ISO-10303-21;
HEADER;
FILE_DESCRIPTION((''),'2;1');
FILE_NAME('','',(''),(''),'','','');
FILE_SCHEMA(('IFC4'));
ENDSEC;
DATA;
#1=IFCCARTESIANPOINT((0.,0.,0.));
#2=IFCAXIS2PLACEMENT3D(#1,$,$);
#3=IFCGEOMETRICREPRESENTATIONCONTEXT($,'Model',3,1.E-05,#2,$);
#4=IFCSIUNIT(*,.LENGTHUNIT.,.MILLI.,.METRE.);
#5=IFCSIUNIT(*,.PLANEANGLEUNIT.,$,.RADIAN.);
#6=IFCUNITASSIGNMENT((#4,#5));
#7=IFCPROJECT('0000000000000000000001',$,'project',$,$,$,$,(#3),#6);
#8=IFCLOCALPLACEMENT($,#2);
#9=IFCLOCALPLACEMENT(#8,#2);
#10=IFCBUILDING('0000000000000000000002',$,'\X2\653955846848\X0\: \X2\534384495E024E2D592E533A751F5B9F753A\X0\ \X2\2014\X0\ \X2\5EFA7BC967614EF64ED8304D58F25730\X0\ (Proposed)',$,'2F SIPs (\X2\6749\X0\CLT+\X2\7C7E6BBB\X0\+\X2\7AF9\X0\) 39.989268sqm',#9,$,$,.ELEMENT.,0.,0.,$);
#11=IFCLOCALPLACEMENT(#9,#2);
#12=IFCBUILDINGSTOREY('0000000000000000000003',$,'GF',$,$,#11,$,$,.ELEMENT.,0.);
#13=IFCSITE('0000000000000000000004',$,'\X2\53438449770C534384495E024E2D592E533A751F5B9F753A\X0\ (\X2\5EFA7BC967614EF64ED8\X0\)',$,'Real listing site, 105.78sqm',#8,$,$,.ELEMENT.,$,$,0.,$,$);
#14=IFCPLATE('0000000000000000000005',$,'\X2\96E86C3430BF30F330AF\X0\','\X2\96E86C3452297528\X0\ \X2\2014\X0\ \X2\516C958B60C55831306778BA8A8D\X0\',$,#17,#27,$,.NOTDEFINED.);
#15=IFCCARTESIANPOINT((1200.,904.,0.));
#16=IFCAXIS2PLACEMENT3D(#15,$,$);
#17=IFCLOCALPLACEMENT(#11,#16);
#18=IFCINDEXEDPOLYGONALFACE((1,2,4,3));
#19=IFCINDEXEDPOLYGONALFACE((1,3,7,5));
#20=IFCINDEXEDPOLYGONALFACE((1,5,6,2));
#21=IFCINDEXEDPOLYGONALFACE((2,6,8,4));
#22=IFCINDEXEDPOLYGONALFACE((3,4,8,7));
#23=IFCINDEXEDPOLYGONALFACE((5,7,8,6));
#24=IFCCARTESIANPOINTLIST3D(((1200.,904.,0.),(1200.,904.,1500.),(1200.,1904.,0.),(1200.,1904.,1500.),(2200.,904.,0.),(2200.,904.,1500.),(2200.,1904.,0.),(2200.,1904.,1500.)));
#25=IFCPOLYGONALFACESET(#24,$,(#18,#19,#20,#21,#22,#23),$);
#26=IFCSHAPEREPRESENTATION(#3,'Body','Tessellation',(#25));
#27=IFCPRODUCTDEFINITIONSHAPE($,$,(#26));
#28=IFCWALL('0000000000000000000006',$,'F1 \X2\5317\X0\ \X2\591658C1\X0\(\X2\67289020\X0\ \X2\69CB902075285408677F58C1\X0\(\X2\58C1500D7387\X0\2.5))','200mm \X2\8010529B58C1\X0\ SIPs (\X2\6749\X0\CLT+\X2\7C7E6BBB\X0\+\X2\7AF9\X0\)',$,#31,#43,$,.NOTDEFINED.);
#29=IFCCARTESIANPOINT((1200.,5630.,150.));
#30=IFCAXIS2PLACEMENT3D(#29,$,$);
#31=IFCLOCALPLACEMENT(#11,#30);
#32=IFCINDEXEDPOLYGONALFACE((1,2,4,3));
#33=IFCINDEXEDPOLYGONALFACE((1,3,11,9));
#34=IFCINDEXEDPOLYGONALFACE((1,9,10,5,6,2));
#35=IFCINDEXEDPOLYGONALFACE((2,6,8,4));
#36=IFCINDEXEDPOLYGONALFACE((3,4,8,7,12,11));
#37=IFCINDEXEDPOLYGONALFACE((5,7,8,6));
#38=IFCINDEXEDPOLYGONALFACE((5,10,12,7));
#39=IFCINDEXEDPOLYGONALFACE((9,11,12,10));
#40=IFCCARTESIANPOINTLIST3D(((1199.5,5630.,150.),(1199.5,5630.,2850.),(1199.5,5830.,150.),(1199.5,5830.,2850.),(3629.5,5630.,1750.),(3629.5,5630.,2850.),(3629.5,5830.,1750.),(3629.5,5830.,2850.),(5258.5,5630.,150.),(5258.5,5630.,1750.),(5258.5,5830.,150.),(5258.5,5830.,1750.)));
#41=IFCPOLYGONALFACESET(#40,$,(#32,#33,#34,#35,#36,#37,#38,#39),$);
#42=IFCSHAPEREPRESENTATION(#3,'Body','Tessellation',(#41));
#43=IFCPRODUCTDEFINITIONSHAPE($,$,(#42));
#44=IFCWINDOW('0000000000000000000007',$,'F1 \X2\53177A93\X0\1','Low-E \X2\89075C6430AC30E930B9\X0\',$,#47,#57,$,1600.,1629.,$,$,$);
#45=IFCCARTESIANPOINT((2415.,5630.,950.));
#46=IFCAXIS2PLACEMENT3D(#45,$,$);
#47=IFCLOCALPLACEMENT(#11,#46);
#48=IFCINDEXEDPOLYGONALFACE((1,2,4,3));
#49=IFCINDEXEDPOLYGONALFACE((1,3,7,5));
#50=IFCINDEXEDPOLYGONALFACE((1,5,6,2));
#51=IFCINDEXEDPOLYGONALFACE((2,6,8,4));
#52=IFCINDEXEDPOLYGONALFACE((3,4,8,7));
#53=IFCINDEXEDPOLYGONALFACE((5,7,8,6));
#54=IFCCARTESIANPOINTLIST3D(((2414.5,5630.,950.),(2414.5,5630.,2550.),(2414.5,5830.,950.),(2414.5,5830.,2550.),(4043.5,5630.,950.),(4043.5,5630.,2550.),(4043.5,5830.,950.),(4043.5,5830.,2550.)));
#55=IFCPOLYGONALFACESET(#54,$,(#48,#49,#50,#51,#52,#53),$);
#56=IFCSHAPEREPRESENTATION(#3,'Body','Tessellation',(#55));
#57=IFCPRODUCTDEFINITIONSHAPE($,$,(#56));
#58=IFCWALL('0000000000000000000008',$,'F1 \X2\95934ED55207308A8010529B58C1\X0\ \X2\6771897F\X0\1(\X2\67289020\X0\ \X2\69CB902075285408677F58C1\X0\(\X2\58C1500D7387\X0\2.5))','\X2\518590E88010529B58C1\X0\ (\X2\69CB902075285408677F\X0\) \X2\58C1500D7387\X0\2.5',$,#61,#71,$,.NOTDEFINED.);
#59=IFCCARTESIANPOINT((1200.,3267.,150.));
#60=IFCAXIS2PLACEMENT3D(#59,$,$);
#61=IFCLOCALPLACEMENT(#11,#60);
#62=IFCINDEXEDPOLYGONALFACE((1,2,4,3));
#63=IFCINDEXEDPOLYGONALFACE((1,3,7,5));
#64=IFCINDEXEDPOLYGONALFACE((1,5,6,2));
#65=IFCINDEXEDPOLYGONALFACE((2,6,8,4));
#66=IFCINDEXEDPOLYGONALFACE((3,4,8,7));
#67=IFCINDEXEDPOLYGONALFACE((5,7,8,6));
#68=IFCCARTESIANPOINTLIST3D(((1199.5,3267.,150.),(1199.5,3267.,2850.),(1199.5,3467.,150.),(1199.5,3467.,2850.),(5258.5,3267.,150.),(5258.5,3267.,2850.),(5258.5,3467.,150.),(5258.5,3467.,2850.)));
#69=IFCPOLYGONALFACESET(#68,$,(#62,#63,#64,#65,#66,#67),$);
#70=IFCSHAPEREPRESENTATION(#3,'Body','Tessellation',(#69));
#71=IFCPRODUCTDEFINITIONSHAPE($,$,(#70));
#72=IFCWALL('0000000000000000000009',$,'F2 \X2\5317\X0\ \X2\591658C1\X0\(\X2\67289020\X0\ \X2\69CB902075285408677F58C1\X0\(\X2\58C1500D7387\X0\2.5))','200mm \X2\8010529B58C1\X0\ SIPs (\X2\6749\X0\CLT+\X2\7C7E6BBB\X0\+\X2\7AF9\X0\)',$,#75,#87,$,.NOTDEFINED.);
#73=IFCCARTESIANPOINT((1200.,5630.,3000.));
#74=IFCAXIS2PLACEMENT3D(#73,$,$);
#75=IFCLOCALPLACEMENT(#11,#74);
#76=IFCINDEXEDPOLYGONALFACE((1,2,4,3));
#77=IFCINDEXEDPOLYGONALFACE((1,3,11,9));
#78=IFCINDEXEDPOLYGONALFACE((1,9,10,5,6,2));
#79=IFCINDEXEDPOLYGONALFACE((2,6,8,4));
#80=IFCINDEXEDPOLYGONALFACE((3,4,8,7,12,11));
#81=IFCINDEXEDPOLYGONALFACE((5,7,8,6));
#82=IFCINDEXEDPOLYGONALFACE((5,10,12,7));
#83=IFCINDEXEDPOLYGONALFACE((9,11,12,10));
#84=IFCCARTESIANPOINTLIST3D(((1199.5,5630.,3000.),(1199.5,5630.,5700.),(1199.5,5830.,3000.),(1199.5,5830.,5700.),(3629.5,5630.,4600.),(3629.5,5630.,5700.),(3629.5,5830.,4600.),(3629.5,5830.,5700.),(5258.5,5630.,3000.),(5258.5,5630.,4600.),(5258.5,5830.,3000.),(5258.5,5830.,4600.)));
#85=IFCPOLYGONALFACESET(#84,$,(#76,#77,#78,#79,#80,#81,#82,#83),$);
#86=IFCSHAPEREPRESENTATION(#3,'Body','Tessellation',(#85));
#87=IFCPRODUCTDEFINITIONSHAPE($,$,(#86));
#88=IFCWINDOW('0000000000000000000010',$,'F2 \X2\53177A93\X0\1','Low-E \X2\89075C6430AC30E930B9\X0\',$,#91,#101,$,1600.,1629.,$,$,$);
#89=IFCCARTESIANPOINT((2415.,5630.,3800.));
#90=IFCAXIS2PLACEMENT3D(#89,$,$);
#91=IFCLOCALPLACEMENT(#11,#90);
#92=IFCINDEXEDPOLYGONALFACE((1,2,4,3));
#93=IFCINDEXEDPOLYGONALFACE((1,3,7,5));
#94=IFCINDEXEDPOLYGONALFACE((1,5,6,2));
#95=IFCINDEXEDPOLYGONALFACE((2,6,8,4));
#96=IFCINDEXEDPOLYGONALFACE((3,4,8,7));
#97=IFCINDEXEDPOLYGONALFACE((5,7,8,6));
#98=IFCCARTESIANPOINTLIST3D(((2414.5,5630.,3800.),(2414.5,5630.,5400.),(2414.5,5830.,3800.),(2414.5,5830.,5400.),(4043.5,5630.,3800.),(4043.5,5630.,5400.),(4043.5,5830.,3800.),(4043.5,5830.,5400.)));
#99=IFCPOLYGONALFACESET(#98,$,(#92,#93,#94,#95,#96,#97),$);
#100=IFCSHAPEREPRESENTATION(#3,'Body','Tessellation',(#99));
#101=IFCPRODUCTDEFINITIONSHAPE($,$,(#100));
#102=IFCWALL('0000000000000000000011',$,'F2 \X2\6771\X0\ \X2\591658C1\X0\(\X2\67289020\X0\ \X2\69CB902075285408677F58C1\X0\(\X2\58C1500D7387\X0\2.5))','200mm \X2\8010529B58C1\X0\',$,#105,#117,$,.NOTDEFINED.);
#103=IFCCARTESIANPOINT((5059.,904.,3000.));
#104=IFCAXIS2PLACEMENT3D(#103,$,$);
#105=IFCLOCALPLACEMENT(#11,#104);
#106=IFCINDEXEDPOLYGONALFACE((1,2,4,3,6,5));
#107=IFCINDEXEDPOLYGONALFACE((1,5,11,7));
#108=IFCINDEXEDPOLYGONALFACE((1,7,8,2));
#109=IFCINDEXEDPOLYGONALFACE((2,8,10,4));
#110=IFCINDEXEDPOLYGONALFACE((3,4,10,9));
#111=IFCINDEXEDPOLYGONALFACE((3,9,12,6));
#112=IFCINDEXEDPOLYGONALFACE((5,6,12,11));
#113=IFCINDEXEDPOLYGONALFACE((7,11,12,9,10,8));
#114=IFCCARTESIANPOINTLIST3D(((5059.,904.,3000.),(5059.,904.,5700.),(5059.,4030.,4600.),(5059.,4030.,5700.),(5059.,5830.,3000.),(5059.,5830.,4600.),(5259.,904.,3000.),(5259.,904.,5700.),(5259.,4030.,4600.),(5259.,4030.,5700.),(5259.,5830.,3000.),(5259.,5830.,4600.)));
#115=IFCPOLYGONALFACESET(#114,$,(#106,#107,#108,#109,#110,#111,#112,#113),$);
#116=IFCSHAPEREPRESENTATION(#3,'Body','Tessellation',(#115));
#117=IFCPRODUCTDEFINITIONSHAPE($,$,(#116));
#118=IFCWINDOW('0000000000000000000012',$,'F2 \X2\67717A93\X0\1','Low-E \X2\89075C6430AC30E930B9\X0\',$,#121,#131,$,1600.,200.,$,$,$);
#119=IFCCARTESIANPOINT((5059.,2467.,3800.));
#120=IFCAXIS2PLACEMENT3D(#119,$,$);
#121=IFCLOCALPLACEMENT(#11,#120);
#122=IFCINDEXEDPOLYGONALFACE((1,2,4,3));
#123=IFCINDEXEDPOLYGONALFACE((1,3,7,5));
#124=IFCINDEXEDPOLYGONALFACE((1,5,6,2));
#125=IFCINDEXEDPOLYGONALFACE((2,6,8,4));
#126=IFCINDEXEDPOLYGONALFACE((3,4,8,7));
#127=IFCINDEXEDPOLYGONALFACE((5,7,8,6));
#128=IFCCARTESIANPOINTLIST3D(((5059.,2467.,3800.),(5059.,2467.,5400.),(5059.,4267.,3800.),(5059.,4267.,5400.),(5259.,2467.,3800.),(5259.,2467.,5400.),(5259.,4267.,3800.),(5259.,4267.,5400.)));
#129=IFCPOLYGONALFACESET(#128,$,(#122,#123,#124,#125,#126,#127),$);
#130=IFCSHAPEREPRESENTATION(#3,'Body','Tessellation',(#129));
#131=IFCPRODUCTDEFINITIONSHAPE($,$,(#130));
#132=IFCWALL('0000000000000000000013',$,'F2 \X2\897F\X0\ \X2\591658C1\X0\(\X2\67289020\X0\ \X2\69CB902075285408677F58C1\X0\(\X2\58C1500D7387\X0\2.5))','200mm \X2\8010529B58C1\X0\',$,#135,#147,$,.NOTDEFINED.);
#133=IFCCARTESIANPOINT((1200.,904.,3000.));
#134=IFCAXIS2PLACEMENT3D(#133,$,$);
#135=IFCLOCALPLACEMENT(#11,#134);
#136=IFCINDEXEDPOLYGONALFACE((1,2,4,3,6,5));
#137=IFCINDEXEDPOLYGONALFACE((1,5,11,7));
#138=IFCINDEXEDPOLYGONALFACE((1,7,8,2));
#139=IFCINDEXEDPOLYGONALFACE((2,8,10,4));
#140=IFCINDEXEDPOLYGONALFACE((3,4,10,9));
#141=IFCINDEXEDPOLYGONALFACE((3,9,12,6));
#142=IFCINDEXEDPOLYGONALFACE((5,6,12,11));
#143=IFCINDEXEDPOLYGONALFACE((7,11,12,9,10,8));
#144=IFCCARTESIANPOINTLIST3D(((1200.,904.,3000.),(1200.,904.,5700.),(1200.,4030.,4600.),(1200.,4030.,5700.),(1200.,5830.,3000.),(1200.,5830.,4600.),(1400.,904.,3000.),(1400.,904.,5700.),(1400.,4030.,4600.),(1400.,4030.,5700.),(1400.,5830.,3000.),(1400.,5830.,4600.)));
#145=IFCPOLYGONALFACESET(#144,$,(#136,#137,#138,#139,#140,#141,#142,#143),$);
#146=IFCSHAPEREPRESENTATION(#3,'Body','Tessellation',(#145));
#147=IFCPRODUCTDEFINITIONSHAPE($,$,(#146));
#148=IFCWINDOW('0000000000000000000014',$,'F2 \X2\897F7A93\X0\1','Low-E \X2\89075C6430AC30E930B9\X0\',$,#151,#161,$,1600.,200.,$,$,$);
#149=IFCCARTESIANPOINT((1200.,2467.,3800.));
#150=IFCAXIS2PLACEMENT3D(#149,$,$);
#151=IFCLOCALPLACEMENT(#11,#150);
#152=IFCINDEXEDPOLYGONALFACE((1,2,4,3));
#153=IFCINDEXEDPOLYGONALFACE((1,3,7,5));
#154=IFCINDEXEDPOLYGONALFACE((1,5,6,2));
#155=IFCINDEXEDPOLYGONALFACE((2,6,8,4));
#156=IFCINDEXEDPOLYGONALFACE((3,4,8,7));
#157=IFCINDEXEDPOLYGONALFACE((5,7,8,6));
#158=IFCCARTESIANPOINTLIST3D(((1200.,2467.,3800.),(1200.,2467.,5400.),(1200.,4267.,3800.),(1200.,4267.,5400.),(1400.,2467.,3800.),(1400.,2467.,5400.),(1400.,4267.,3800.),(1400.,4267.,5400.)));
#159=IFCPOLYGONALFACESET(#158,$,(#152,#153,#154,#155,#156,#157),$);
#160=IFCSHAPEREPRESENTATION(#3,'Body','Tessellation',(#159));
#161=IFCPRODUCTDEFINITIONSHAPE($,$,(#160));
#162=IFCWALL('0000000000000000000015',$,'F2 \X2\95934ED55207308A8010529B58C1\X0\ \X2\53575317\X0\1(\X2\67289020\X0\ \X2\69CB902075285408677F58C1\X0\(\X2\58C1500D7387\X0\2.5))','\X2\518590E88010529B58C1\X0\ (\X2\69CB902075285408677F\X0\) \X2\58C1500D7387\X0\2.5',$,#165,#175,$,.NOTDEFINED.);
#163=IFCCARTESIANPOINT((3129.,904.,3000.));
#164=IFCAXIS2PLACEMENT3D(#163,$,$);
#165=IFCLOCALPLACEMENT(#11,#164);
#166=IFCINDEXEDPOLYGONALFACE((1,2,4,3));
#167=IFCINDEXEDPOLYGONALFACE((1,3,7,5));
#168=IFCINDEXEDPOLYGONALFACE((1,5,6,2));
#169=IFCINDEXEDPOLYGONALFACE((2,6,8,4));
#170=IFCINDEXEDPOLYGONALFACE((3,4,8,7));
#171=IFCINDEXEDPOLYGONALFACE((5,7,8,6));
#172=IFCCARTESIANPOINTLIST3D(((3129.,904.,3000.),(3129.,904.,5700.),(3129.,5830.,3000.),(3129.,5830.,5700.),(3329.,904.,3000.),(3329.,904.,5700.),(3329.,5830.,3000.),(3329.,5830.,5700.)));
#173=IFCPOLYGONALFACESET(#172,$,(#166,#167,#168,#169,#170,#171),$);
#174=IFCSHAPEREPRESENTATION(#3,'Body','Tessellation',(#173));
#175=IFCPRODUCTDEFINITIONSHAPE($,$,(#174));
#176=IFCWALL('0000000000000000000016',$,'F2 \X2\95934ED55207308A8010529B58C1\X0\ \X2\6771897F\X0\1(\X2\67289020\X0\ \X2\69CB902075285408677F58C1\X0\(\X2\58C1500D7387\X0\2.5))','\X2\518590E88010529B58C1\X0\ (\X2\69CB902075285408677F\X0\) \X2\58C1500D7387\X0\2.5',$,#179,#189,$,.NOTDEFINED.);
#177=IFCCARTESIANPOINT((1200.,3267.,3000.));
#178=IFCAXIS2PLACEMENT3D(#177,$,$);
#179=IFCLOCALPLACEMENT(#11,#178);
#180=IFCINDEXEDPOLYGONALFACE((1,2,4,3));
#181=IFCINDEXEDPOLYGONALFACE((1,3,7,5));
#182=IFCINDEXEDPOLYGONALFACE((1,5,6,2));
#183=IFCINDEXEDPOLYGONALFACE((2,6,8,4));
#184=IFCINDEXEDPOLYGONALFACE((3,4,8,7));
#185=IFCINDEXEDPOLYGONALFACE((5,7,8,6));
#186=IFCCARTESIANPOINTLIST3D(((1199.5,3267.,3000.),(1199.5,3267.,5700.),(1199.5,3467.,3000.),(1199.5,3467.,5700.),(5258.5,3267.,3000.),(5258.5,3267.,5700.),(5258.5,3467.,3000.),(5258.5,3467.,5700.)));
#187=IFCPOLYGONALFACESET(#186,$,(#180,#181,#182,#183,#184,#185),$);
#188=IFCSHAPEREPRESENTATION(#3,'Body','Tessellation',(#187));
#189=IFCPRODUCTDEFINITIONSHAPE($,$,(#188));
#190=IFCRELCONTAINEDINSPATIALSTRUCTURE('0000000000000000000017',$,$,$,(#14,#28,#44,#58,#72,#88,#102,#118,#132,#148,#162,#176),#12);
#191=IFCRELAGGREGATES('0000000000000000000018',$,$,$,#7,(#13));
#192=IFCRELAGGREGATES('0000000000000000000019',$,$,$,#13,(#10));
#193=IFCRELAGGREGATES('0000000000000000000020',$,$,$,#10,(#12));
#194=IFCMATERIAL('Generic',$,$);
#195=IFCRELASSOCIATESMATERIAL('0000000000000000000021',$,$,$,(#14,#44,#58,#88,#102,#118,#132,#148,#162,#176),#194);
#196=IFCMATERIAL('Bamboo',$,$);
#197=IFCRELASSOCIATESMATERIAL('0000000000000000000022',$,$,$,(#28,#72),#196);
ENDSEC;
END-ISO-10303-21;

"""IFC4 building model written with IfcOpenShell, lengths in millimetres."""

from ifc_helpers import new_model, si_unit, frame, frame_2d, origin, place, context, project, spatial, rectangle, extrude, material, element, fill, save


model = new_model("IFC4")

# Units and contexts
model_context = context("Model", 3, precision=1e-05, world=origin())
ifc_project = project(units=[si_unit("LENGTHUNIT", "METRE", prefix="MILLI"), si_unit("PLANEANGLEUNIT", "RADIAN")], contexts=[model_context])

# Site, building, storey
site_placement = place(None, origin())
site = spatial("IfcSite", under=ifc_project, at=site_placement, Name="千葉県千葉市中央区生実町 (建築条件付)", ObjectType="Real listing site, 105.78sqm", CompositionType="ELEMENT", RefElevation=0.0)
building_placement = place(site_placement, origin())
building = spatial("IfcBuilding", under=site, at=building_placement, Name="改善案: 千葉市中央区生実町 — 建築条件付き売地 (Proposed)", ObjectType="2F SIPs (杉CLT+籾殻+竹) 39.989268sqm", CompositionType="ELEMENT", ElevationOfRefHeight=0.0, ElevationOfTerrain=0.0)
storey_placement = place(building_placement, origin())
storey = spatial("IfcBuildingStorey", under=building, at=storey_placement, Name="GF", CompositionType="ELEMENT", Elevation=0.0)

# Plate
ifc_material_1 = material(Name="Generic")
plate_placement = place(storey_placement, frame((1200.0, 904.0, 0.0)))
element("IfcPlate", 1, at=plate_placement, inside=storey, material=ifc_material_1, Name="雨水タンク", Description="雨水利用 — 公開情報で確認", PredefinedType="NOTDEFINED", context=model_context, shape_type="SweptSolid", body=[
    extrude(rectangle(XDim=1000.0, YDim=1000.0, at=frame_2d((500.0, 500.0))), frame((1200.0, 904.0, 0.0)), (0.0, 0.0, 1.0), 1500.0),
])

# Wall, opening, window
ifc_material_2 = material(Name="Bamboo")
wall_1_placement = place(storey_placement, frame((1200.0, 5630.0, 150.0)))
wall_1 = element("IfcWall", 2, at=wall_1_placement, inside=storey, material=ifc_material_2, Name="F1 北 外壁(木造 構造用合板壁(壁倍率2.5))", Description="200mm 耐力壁 SIPs (杉CLT+籾殻+竹)", PredefinedType="NOTDEFINED", context=model_context, shape_type="SweptSolid", body=[
    extrude(rectangle(XDim=4059.0, YDim=200.0, at=frame_2d((2029.0, 100.0))), frame((1200.0, 5630.0, 150.0)), (0.0, 0.0, 1.0), 2700.0),
])
opening_1_placement = place(storey_placement, frame((2415.0, 5630.0, 950.0)))
opening_1 = element("IfcOpeningElement", 3, at=opening_1_placement, cuts=wall_1, PredefinedType="NOTDEFINED", context=model_context, shape_type="SweptSolid", body=[
    extrude(rectangle(XDim=1629.0, YDim=200.0, at=frame_2d((814.0, 100.0))), frame((2415.0, 5630.0, 950.0)), (0.0, 0.0, 1.0), 1600.0),
])
window_1_placement = place(storey_placement, frame((2415.0, 5630.0, 950.0)))
window_1 = element("IfcWindow", 4, at=window_1_placement, inside=storey, material=ifc_material_1, Name="F1 北窓1", Description="Low-E 複層ガラス", OverallHeight=1600.0, OverallWidth=1629.0, context=model_context, shape_type="SweptSolid", body=[
    extrude(rectangle(XDim=1629.0, YDim=200.0, at=frame_2d((814.0, 100.0))), frame((2415.0, 5630.0, 950.0)), (0.0, 0.0, 1.0), 1600.0),
])
fill(opening_1, window_1)

# Wall
wall_2_placement = place(storey_placement, frame((1200.0, 3267.0, 150.0)))
element("IfcWall", 5, at=wall_2_placement, inside=storey, material=ifc_material_1, Name="F1 間仕切り耐力壁 東西1(木造 構造用合板壁(壁倍率2.5))", Description="内部耐力壁 (構造用合板) 壁倍率2.5", PredefinedType="NOTDEFINED", context=model_context, shape_type="SweptSolid", body=[
    extrude(rectangle(XDim=4059.0, YDim=200.0, at=frame_2d((2029.0, 100.0))), frame((1200.0, 3267.0, 150.0)), (0.0, 0.0, 1.0), 2700.0),
])

# Walls, openings, windows
wall_3_placement = place(storey_placement, frame((1200.0, 5630.0, 3000.0)))
wall_3 = element("IfcWall", 6, at=wall_3_placement, inside=storey, material=ifc_material_2, Name="F2 北 外壁(木造 構造用合板壁(壁倍率2.5))", Description="200mm 耐力壁 SIPs (杉CLT+籾殻+竹)", PredefinedType="NOTDEFINED", context=model_context, shape_type="SweptSolid", body=[
    extrude(rectangle(XDim=4059.0, YDim=200.0, at=frame_2d((2029.0, 100.0))), frame((1200.0, 5630.0, 3000.0)), (0.0, 0.0, 1.0), 2700.0),
])
opening_2_placement = place(storey_placement, frame((2415.0, 5630.0, 3800.0)))
opening_2 = element("IfcOpeningElement", 7, at=opening_2_placement, cuts=wall_3, PredefinedType="NOTDEFINED", context=model_context, shape_type="SweptSolid", body=[
    extrude(rectangle(XDim=1629.0, YDim=200.0, at=frame_2d((814.0, 100.0))), frame((2415.0, 5630.0, 3800.0)), (0.0, 0.0, 1.0), 1600.0),
])
window_2_placement = place(storey_placement, frame((2415.0, 5630.0, 3800.0)))
window_2 = element("IfcWindow", 8, at=window_2_placement, inside=storey, material=ifc_material_1, Name="F2 北窓1", Description="Low-E 複層ガラス", OverallHeight=1600.0, OverallWidth=1629.0, context=model_context, shape_type="SweptSolid", body=[
    extrude(rectangle(XDim=1629.0, YDim=200.0, at=frame_2d((814.0, 100.0))), frame((2415.0, 5630.0, 3800.0)), (0.0, 0.0, 1.0), 1600.0),
])
fill(opening_2, window_2)
wall_4_placement = place(storey_placement, frame((5059.0, 904.0, 3000.0)))
wall_4 = element("IfcWall", 9, at=wall_4_placement, inside=storey, material=ifc_material_1, Name="F2 東 外壁(木造 構造用合板壁(壁倍率2.5))", Description="200mm 耐力壁", PredefinedType="NOTDEFINED", context=model_context, shape_type="SweptSolid", body=[
    extrude(rectangle(XDim=200.0, YDim=4926.0, at=frame_2d((100.0, 2463.0))), frame((5059.0, 904.0, 3000.0)), (0.0, 0.0, 1.0), 2700.0),
])
opening_3_placement = place(storey_placement, frame((5059.0, 2467.0, 3800.0)))
opening_3 = element("IfcOpeningElement", 10, at=opening_3_placement, cuts=wall_4, PredefinedType="NOTDEFINED", context=model_context, shape_type="SweptSolid", body=[
    extrude(rectangle(XDim=200.0, YDim=1800.0, at=frame_2d((100.0, 900.0))), frame((5059.0, 2467.0, 3800.0)), (0.0, 0.0, 1.0), 1600.0),
])
window_3_placement = place(storey_placement, frame((5059.0, 2467.0, 3800.0)))
window_3 = element("IfcWindow", 11, at=window_3_placement, inside=storey, material=ifc_material_1, Name="F2 東窓1", Description="Low-E 複層ガラス", OverallHeight=1600.0, OverallWidth=200.0, context=model_context, shape_type="SweptSolid", body=[
    extrude(rectangle(XDim=200.0, YDim=1800.0, at=frame_2d((100.0, 900.0))), frame((5059.0, 2467.0, 3800.0)), (0.0, 0.0, 1.0), 1600.0),
])
fill(opening_3, window_3)
wall_5_placement = place(storey_placement, frame((1200.0, 904.0, 3000.0)))
wall_5 = element("IfcWall", 12, at=wall_5_placement, inside=storey, material=ifc_material_1, Name="F2 西 外壁(木造 構造用合板壁(壁倍率2.5))", Description="200mm 耐力壁", PredefinedType="NOTDEFINED", context=model_context, shape_type="SweptSolid", body=[
    extrude(rectangle(XDim=200.0, YDim=4926.0, at=frame_2d((100.0, 2463.0))), frame((1200.0, 904.0, 3000.0)), (0.0, 0.0, 1.0), 2700.0),
])
opening_4_placement = place(storey_placement, frame((1200.0, 2467.0, 3800.0)))
opening_4 = element("IfcOpeningElement", 13, at=opening_4_placement, cuts=wall_5, PredefinedType="NOTDEFINED", context=model_context, shape_type="SweptSolid", body=[
    extrude(rectangle(XDim=200.0, YDim=1800.0, at=frame_2d((100.0, 900.0))), frame((1200.0, 2467.0, 3800.0)), (0.0, 0.0, 1.0), 1600.0),
])
window_4_placement = place(storey_placement, frame((1200.0, 2467.0, 3800.0)))
window_4 = element("IfcWindow", 14, at=window_4_placement, inside=storey, material=ifc_material_1, Name="F2 西窓1", Description="Low-E 複層ガラス", OverallHeight=1600.0, OverallWidth=200.0, context=model_context, shape_type="SweptSolid", body=[
    extrude(rectangle(XDim=200.0, YDim=1800.0, at=frame_2d((100.0, 900.0))), frame((1200.0, 2467.0, 3800.0)), (0.0, 0.0, 1.0), 1600.0),
])
fill(opening_4, window_4)

# Walls
wall_6_placement = place(storey_placement, frame((3129.0, 904.0, 3000.0)))
element("IfcWall", 15, at=wall_6_placement, inside=storey, material=ifc_material_1, Name="F2 間仕切り耐力壁 南北1(木造 構造用合板壁(壁倍率2.5))", Description="内部耐力壁 (構造用合板) 壁倍率2.5", PredefinedType="NOTDEFINED", context=model_context, shape_type="SweptSolid", body=[
    extrude(rectangle(XDim=200.0, YDim=4926.0, at=frame_2d((100.0, 2463.0))), frame((3129.0, 904.0, 3000.0)), (0.0, 0.0, 1.0), 2700.0),
])
wall_7_placement = place(storey_placement, frame((1200.0, 3267.0, 3000.0)))
element("IfcWall", 16, at=wall_7_placement, inside=storey, material=ifc_material_1, Name="F2 間仕切り耐力壁 東西1(木造 構造用合板壁(壁倍率2.5))", Description="内部耐力壁 (構造用合板) 壁倍率2.5", PredefinedType="NOTDEFINED", context=model_context, shape_type="SweptSolid", body=[
    extrude(rectangle(XDim=4059.0, YDim=200.0, at=frame_2d((2029.0, 100.0))), frame((1200.0, 3267.0, 3000.0)), (0.0, 0.0, 1.0), 2700.0),
])

save(model, "model.ifc")
